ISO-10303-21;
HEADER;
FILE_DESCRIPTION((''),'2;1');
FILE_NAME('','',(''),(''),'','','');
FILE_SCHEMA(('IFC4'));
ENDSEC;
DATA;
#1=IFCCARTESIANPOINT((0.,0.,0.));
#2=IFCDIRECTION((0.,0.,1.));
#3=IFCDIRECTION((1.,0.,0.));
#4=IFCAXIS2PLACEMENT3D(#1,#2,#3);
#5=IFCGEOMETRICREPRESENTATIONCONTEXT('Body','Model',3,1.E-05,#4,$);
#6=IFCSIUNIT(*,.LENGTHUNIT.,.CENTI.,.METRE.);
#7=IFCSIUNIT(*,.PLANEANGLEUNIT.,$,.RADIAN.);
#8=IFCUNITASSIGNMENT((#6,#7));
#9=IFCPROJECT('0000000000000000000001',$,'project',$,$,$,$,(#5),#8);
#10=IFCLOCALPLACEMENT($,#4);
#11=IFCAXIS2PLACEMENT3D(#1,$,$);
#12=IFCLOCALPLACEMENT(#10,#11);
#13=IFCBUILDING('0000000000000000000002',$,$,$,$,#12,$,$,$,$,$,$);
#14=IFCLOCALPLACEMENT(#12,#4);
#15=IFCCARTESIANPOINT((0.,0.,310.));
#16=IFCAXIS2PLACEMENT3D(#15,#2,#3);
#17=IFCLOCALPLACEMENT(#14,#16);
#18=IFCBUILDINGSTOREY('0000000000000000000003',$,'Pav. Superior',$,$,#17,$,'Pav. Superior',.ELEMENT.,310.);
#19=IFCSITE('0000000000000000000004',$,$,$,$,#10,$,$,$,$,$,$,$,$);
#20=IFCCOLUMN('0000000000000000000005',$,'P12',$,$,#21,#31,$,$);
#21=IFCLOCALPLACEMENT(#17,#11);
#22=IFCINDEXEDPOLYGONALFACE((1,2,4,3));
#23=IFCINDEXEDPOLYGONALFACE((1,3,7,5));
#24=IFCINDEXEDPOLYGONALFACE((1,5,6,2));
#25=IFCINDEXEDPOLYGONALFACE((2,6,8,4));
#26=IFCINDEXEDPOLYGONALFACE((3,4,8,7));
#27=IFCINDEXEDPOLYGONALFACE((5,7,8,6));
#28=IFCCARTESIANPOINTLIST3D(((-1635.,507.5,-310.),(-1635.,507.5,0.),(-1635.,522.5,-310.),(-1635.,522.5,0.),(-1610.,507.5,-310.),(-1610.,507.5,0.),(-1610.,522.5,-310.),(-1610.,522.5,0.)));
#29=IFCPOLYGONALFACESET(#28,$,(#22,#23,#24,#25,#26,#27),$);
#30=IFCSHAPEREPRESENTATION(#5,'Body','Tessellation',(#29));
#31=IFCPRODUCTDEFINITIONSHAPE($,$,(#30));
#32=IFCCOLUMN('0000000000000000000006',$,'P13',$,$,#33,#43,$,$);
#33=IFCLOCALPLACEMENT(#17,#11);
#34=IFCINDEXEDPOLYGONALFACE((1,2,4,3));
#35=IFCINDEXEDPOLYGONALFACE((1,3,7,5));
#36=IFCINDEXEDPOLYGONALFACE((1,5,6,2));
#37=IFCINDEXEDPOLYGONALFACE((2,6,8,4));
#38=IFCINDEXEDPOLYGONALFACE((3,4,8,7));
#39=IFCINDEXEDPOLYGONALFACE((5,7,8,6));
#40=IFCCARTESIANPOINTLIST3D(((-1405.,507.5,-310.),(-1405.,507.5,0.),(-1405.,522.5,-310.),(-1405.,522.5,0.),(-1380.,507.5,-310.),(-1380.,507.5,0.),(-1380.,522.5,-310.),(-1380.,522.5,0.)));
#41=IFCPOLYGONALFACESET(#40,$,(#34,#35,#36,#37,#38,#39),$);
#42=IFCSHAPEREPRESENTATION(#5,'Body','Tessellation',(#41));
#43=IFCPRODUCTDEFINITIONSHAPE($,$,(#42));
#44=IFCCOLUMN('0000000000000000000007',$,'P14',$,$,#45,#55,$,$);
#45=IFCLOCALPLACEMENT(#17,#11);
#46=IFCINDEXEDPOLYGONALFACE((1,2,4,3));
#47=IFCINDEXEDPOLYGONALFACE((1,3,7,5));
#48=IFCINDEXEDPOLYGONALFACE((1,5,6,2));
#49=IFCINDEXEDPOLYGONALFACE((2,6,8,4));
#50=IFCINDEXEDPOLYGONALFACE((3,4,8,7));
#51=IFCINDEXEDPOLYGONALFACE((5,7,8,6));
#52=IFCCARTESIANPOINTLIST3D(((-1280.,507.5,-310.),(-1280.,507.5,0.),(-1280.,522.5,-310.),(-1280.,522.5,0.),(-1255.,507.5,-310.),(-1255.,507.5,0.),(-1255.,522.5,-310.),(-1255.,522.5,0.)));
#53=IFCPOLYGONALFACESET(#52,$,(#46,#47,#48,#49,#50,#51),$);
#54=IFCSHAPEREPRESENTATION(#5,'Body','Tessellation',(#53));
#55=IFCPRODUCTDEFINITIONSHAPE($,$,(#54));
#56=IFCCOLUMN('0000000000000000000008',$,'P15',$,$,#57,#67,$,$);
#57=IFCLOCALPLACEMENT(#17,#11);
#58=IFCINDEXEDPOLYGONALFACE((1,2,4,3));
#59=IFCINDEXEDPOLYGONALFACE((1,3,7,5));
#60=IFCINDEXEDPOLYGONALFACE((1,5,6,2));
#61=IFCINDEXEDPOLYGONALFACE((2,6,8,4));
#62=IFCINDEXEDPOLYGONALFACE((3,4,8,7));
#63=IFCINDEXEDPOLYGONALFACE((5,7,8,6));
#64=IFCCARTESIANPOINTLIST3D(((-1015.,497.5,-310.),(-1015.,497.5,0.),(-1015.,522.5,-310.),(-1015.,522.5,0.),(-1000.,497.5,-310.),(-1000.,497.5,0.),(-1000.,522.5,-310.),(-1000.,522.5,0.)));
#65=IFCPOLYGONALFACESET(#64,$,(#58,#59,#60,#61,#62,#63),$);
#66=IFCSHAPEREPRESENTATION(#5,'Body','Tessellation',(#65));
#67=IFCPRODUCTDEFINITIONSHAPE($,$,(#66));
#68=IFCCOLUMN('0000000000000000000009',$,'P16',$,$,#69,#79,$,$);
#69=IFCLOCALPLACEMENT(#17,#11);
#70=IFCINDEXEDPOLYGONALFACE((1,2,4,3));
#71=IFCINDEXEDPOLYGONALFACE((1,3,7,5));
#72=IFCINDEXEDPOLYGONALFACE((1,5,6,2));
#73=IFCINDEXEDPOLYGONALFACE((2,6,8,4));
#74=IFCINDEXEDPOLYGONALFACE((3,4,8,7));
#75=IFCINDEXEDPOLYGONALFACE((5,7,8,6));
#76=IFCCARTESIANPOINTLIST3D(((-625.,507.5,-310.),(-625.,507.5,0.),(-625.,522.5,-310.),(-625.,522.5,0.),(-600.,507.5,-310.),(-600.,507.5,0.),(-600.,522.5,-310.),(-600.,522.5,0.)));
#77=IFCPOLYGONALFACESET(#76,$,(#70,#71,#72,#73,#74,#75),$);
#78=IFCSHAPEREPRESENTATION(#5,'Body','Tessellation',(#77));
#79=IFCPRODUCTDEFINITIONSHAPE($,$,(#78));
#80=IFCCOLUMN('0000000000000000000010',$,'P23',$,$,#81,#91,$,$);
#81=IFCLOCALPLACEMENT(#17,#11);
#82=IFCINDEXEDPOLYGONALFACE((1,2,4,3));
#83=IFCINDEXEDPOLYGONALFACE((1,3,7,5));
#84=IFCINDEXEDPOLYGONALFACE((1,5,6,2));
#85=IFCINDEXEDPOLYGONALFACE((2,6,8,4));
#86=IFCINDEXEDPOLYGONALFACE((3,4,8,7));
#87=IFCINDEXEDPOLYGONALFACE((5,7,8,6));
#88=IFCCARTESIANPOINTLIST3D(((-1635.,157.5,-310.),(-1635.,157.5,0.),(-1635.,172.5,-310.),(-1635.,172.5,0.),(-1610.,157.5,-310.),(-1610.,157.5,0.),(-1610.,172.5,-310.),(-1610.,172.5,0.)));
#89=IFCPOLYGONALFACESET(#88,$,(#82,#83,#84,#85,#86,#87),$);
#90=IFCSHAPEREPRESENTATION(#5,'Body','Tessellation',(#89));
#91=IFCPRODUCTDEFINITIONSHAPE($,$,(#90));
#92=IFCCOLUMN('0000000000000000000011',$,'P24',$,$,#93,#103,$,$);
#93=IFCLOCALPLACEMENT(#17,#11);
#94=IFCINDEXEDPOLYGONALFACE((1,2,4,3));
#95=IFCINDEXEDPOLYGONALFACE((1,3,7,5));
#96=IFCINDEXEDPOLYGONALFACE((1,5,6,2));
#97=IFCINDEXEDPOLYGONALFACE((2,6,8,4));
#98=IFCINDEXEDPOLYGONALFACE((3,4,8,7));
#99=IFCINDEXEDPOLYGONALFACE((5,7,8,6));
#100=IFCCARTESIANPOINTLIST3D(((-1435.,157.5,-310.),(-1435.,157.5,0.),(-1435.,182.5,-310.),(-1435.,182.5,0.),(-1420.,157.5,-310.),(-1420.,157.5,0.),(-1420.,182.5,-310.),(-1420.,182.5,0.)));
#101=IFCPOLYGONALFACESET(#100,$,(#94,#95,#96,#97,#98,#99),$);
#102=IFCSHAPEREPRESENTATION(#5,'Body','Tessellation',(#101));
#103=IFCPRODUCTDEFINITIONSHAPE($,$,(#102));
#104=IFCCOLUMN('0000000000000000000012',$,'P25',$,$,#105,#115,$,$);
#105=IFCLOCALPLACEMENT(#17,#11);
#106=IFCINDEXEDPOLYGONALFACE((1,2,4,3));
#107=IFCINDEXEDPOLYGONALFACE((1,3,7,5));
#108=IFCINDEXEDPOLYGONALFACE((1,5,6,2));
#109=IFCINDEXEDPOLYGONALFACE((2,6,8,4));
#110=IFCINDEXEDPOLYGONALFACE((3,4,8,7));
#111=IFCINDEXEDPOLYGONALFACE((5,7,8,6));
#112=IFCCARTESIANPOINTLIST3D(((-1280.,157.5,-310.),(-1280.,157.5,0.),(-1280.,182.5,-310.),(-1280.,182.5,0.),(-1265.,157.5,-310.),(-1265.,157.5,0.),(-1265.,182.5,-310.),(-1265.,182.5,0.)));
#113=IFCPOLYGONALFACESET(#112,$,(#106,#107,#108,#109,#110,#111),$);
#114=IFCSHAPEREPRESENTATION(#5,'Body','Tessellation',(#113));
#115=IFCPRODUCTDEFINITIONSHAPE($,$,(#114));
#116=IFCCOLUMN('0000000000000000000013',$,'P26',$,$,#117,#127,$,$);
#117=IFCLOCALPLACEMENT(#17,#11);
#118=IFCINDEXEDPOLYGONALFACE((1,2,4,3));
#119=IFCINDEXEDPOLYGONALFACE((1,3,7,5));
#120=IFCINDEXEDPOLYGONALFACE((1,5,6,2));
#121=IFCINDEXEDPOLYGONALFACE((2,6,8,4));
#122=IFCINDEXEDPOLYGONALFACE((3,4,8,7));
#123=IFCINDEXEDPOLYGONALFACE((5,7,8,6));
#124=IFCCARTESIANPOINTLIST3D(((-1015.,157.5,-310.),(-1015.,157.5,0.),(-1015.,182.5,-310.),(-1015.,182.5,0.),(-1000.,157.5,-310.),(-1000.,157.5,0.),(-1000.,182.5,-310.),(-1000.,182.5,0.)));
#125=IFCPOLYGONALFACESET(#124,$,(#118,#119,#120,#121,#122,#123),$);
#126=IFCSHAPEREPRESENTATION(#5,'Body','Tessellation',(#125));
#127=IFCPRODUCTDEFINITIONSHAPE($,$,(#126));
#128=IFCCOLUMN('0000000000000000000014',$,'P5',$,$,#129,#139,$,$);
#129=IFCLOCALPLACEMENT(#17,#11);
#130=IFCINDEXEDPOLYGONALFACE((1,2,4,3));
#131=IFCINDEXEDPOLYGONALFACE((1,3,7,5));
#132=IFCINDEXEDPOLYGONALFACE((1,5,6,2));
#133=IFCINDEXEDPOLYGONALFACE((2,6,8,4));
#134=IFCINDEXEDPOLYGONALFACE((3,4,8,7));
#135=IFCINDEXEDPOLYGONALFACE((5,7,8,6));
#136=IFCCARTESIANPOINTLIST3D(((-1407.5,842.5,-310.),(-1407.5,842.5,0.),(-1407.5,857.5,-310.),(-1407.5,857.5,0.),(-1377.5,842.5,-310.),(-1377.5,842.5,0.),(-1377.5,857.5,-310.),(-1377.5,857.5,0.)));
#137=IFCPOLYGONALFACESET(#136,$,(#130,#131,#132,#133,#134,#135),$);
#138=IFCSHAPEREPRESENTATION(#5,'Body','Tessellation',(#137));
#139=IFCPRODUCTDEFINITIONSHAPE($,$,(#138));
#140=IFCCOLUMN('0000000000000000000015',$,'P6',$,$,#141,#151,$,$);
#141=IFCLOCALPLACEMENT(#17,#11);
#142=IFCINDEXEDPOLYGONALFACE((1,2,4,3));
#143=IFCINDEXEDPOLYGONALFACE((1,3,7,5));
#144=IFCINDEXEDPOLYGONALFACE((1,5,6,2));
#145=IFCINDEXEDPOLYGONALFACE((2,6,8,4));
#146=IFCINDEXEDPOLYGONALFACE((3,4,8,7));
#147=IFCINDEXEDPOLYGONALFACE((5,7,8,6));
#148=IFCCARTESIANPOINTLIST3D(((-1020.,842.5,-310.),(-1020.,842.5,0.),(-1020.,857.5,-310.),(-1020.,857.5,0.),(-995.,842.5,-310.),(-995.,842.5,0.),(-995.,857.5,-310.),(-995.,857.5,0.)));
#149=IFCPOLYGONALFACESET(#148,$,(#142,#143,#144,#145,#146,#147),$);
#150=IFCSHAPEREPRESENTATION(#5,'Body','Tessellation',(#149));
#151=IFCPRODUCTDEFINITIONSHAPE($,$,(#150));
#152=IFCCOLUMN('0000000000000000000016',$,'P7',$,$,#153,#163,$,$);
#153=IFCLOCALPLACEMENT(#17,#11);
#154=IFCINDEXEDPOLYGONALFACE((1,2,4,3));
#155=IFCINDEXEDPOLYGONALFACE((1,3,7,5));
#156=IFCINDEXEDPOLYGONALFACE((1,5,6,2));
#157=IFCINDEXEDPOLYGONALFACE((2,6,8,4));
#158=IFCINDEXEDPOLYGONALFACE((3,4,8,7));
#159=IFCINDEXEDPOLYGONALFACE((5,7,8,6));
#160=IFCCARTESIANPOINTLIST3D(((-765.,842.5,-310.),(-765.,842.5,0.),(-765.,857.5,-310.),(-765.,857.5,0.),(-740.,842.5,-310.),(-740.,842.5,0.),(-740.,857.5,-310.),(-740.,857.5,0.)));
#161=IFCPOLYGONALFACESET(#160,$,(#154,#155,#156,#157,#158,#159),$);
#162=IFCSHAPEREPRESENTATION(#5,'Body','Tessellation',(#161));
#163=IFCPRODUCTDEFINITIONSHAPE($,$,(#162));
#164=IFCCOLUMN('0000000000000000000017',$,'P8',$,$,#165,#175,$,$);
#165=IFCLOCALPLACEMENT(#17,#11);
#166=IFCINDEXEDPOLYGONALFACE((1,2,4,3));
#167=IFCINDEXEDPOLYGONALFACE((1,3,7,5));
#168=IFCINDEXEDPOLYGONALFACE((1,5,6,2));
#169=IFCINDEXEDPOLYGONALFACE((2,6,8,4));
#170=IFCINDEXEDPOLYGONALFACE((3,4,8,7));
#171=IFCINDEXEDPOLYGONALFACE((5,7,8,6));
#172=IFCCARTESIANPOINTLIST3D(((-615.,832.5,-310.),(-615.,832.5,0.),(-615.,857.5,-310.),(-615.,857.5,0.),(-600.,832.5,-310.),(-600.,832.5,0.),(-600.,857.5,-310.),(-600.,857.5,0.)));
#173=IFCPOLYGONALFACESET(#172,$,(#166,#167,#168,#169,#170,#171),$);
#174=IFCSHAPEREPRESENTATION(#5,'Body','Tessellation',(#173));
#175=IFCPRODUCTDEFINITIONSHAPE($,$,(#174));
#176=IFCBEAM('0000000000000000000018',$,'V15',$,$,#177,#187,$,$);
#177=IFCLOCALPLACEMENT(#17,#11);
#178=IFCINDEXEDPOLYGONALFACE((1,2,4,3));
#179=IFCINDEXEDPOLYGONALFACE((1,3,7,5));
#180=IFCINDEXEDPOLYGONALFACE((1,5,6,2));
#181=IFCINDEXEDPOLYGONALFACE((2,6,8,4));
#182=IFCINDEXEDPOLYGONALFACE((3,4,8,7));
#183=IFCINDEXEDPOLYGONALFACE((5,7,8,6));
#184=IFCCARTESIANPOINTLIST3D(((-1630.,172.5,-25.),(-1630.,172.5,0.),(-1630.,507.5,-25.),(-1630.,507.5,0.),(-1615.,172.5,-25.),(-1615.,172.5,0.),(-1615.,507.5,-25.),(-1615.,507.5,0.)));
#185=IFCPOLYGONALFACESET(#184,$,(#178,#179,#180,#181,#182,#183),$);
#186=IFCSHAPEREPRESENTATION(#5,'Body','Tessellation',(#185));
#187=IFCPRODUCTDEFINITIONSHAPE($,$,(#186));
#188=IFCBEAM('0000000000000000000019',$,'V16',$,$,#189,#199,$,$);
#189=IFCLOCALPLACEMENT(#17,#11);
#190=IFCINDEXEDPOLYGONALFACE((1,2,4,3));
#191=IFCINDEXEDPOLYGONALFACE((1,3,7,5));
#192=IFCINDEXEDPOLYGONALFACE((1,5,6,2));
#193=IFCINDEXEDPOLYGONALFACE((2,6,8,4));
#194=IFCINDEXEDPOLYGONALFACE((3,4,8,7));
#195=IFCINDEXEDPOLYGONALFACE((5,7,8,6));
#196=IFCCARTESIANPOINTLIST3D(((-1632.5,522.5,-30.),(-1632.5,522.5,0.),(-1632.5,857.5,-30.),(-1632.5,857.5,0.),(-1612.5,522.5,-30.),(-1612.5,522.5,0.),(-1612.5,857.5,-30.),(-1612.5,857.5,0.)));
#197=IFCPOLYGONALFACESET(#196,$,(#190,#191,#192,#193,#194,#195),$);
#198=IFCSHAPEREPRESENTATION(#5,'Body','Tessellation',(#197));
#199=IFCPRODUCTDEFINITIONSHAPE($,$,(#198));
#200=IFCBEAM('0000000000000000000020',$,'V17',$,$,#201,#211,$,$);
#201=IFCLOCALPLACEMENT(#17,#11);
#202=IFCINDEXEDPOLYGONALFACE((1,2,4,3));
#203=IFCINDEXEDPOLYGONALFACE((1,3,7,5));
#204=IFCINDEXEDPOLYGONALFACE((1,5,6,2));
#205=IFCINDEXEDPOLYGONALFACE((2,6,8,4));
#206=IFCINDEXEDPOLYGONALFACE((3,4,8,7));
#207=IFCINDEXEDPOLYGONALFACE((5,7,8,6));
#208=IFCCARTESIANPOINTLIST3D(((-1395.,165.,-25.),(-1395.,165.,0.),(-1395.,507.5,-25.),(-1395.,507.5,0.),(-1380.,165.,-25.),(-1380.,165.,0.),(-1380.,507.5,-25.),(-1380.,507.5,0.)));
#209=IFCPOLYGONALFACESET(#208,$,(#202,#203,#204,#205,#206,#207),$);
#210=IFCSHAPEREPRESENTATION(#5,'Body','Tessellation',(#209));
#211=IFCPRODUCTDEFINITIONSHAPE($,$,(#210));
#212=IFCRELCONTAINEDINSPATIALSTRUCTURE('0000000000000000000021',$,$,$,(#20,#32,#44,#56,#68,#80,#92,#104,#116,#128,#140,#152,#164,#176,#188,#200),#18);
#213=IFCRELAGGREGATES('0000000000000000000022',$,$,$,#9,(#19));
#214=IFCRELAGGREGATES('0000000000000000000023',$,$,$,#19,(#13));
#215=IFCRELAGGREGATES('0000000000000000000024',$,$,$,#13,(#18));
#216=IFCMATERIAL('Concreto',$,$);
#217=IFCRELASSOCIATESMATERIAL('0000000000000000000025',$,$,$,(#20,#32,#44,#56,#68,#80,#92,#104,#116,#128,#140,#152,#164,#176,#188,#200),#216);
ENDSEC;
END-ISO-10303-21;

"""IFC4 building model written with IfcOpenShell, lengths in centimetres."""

from ifc_helpers import new_model, si_unit, frame, origin, origin_with_axes, origin_2d_with_axis, place, context, project, spatial, rectangle, extrude, material, element, save


model = new_model("IFC4")

# Units and contexts
model_context = context("Model", 3, precision=1e-05, world=origin_with_axes(), identifier="Body")
ifc_project = project(units=[si_unit("LENGTHUNIT", "METRE", prefix="CENTI"), si_unit("PLANEANGLEUNIT", "RADIAN")], contexts=[model_context])

# Site, building, storey
site_placement = place(None, origin_with_axes())
site = spatial("IfcSite", under=ifc_project, at=site_placement)
building_placement = place(site_placement, origin())
building = spatial("IfcBuilding", under=site, at=building_placement)
placement = place(building_placement, origin_with_axes())
storey_placement = place(placement, frame((0.0, 0.0, 310.0), z_axis=(0.0, 0.0, 1.0), x_axis=(1.0, 0.0, 0.0)))
storey = spatial("IfcBuildingStorey", under=building, at=storey_placement, Name="Pav. Superior", LongName="Pav. Superior", CompositionType="ELEMENT", Elevation=310.0)

# Columns
ifc_material = material(Name="Concreto")
for number, where, z_axis, x_axis, name in (
    (1, (-1622.5, 515.0, 0.0), (0.0, 0.0, 1.0), (1.0, 0.0, 0.0), "P12"),
    (2, (-1392.5, 515.0, 0.0), (0.0, 0.0, 1.0), (1.0, 0.0, 0.0), "P13"),
    (3, (-1267.5, 515.0, 0.0), (0.0, 0.0, 1.0), (1.0, 0.0, 0.0), "P14"),
):
    element("IfcColumn", number, at=place(storey_placement, frame(where, z_axis=z_axis, x_axis=x_axis)), inside=storey, material=ifc_material, Name=name, context=model_context, shape_type="SolidModel", body=[
        extrude(rectangle(XDim=15.0, YDim=25.0, at=origin_2d_with_axis()), frame((0.0, 0.0, 0.0), z_axis=(0.0, 0.0, 1.0), x_axis=(0.0, 1.0, 0.0)), (0.0, 0.0, -1.0), 310.0),
    ])
column_1_placement = place(storey_placement, frame((-1007.5, 510.0, 0.0), z_axis=(0.0, 0.0, 1.0), x_axis=(1.0, 0.0, 0.0)))
element("IfcColumn", 4, at=column_1_placement, inside=storey, material=ifc_material, Name="P15", context=model_context, shape_type="SolidModel", body=[
    extrude(rectangle(XDim=15.0, YDim=25.0, at=origin_2d_with_axis()), origin_with_axes(), (0.0, 0.0, -1.0), 310.0),
])
column_2_placement = place(storey_placement, frame((-612.5, 515.0, 0.0), z_axis=(0.0, 0.0, 1.0), x_axis=(1.0, 0.0, 0.0)))
element("IfcColumn", 5, at=column_2_placement, inside=storey, material=ifc_material, Name="P16", context=model_context, shape_type="SolidModel", body=[
    extrude(rectangle(XDim=15.0, YDim=25.0, at=origin_2d_with_axis()), frame((0.0, 0.0, 0.0), z_axis=(0.0, 0.0, 1.0), x_axis=(0.0, -1.0, 0.0)), (0.0, 0.0, -1.0), 310.0),
])
column_3_placement = place(storey_placement, frame((-1622.5, 165.0, 0.0), z_axis=(0.0, 0.0, 1.0), x_axis=(1.0, 0.0, 0.0)))
element("IfcColumn", 6, at=column_3_placement, inside=storey, material=ifc_material, Name="P23", context=model_context, shape_type="SolidModel", body=[
    extrude(rectangle(XDim=15.0, YDim=25.0, at=origin_2d_with_axis()), frame((0.0, 0.0, 0.0), z_axis=(0.0, 0.0, 1.0), x_axis=(0.0, 1.0, 0.0)), (0.0, 0.0, -1.0), 310.0),
])
column_4_placement = place(storey_placement, frame((-1427.5, 170.0, 0.0), z_axis=(0.0, 0.0, 1.0), x_axis=(1.0, 0.0, 0.0)))
element("IfcColumn", 7, at=column_4_placement, inside=storey, material=ifc_material, Name="P24", context=model_context, shape_type="SolidModel", body=[
    extrude(rectangle(XDim=15.0, YDim=25.0, at=origin_2d_with_axis()), origin_with_axes(), (0.0, 0.0, -1.0), 310.0),
])
column_5_placement = place(storey_placement, frame((-1272.5, 170.0, 0.0), z_axis=(0.0, 0.0, 1.0), x_axis=(1.0, 0.0, 0.0)))
element("IfcColumn", 8, at=column_5_placement, inside=storey, material=ifc_material, Name="P25", context=model_context, shape_type="SolidModel", body=[
    extrude(rectangle(XDim=15.0, YDim=25.0, at=origin_2d_with_axis()), frame((0.0, 0.0, 0.0), z_axis=(0.0, 0.0, 1.0), x_axis=(-1.0, 0.0, 0.0)), (0.0, 0.0, -1.0), 310.0),
])
column_6_placement = place(storey_placement, frame((-1007.5, 170.0, 0.0), z_axis=(0.0, 0.0, 1.0), x_axis=(1.0, 0.0, 0.0)))
element("IfcColumn", 9, at=column_6_placement, inside=storey, material=ifc_material, Name="P26", context=model_context, shape_type="SolidModel", body=[
    extrude(rectangle(XDim=15.0, YDim=25.0, at=origin_2d_with_axis()), origin_with_axes(), (0.0, 0.0, -1.0), 310.0),
])
column_7_placement = place(storey_placement, frame((-1392.5, 850.0, 0.0), z_axis=(0.0, 0.0, 1.0), x_axis=(1.0, 0.0, 0.0)))
element("IfcColumn", 10, at=column_7_placement, inside=storey, material=ifc_material, Name="P5", context=model_context, shape_type="SolidModel", body=[
    extrude(rectangle(XDim=15.0, YDim=30.0, at=origin_2d_with_axis()), frame((0.0, 0.0, 0.0), z_axis=(0.0, 0.0, 1.0), x_axis=(0.0, 1.0, 0.0)), (0.0, 0.0, -1.0), 310.0),
])
for number, where, z_axis, x_axis, name in (
    (11, (-1007.5, 850.0, 0.0), (0.0, 0.0, 1.0), (1.0, 0.0, 0.0), "P6"),
    (12, (-752.5, 850.0, 0.0), (0.0, 0.0, 1.0), (1.0, 0.0, 0.0), "P7"),
):
    element("IfcColumn", number, at=place(storey_placement, frame(where, z_axis=z_axis, x_axis=x_axis)), inside=storey, material=ifc_material, Name=name, context=model_context, shape_type="SolidModel", body=[
        extrude(rectangle(XDim=15.0, YDim=25.0, at=origin_2d_with_axis()), frame((0.0, 0.0, 0.0), z_axis=(0.0, 0.0, 1.0), x_axis=(0.0, 1.0, 0.0)), (0.0, 0.0, -1.0), 310.0),
    ])
column_8_placement = place(storey_placement, frame((-607.5, 845.0, 0.0), z_axis=(0.0, 0.0, 1.0), x_axis=(1.0, 0.0, 0.0)))
element("IfcColumn", 13, at=column_8_placement, inside=storey, material=ifc_material, Name="P8", context=model_context, shape_type="SolidModel", body=[
    extrude(rectangle(XDim=15.0, YDim=25.0, at=origin_2d_with_axis()), frame((0.0, 0.0, 0.0), z_axis=(0.0, 0.0, 1.0), x_axis=(-1.0, 0.0, 0.0)), (0.0, 0.0, -1.0), 310.0),
])

# Beams
beam_1_placement = place(storey_placement, frame((-1622.5, 340.0, 0.0), z_axis=(0.0, 0.0, 1.0), x_axis=(1.0, 0.0, 0.0)))
element("IfcBeam", 14, at=beam_1_placement, inside=storey, material=ifc_material, Name="V15", context=model_context, shape_type="SolidModel", body=[
    extrude(rectangle(XDim=15.0, YDim=25.0, at=origin_2d_with_axis()), frame((0.0, -167.5, -12.5), z_axis=(0.0, 1.0, 0.0), x_axis=(-1.0, 0.0, 0.0)), (0.0, 0.0, 1.0), 335.0),
])
beam_2_placement = place(storey_placement, frame((-1622.5, 690.0, 0.0), z_axis=(0.0, 0.0, 1.0), x_axis=(1.0, 0.0, 0.0)))
element("IfcBeam", 15, at=beam_2_placement, inside=storey, material=ifc_material, Name="V16", context=model_context, shape_type="SolidModel", body=[
    extrude(rectangle(XDim=20.0, YDim=30.0, at=origin_2d_with_axis()), frame((0.0, -167.5, -15.0), z_axis=(0.0, 1.0, 0.0), x_axis=(-1.0, 0.0, 0.0)), (0.0, 0.0, 1.0), 335.0),
])
beam_3_placement = place(storey_placement, frame((-1387.5, 336.25, 0.0), z_axis=(0.0, 0.0, 1.0), x_axis=(1.0, 0.0, 0.0)))
element("IfcBeam", 16, at=beam_3_placement, inside=storey, material=ifc_material, Name="V17", context=model_context, shape_type="SolidModel", body=[
    extrude(rectangle(XDim=15.0, YDim=25.0, at=origin_2d_with_axis()), frame((0.0, -171.25, -12.5), z_axis=(0.0, 1.0, 0.0), x_axis=(-1.0, 0.0, 0.0)), (0.0, 0.0, 1.0), 342.5),
])

save(model, "model.ifc")
